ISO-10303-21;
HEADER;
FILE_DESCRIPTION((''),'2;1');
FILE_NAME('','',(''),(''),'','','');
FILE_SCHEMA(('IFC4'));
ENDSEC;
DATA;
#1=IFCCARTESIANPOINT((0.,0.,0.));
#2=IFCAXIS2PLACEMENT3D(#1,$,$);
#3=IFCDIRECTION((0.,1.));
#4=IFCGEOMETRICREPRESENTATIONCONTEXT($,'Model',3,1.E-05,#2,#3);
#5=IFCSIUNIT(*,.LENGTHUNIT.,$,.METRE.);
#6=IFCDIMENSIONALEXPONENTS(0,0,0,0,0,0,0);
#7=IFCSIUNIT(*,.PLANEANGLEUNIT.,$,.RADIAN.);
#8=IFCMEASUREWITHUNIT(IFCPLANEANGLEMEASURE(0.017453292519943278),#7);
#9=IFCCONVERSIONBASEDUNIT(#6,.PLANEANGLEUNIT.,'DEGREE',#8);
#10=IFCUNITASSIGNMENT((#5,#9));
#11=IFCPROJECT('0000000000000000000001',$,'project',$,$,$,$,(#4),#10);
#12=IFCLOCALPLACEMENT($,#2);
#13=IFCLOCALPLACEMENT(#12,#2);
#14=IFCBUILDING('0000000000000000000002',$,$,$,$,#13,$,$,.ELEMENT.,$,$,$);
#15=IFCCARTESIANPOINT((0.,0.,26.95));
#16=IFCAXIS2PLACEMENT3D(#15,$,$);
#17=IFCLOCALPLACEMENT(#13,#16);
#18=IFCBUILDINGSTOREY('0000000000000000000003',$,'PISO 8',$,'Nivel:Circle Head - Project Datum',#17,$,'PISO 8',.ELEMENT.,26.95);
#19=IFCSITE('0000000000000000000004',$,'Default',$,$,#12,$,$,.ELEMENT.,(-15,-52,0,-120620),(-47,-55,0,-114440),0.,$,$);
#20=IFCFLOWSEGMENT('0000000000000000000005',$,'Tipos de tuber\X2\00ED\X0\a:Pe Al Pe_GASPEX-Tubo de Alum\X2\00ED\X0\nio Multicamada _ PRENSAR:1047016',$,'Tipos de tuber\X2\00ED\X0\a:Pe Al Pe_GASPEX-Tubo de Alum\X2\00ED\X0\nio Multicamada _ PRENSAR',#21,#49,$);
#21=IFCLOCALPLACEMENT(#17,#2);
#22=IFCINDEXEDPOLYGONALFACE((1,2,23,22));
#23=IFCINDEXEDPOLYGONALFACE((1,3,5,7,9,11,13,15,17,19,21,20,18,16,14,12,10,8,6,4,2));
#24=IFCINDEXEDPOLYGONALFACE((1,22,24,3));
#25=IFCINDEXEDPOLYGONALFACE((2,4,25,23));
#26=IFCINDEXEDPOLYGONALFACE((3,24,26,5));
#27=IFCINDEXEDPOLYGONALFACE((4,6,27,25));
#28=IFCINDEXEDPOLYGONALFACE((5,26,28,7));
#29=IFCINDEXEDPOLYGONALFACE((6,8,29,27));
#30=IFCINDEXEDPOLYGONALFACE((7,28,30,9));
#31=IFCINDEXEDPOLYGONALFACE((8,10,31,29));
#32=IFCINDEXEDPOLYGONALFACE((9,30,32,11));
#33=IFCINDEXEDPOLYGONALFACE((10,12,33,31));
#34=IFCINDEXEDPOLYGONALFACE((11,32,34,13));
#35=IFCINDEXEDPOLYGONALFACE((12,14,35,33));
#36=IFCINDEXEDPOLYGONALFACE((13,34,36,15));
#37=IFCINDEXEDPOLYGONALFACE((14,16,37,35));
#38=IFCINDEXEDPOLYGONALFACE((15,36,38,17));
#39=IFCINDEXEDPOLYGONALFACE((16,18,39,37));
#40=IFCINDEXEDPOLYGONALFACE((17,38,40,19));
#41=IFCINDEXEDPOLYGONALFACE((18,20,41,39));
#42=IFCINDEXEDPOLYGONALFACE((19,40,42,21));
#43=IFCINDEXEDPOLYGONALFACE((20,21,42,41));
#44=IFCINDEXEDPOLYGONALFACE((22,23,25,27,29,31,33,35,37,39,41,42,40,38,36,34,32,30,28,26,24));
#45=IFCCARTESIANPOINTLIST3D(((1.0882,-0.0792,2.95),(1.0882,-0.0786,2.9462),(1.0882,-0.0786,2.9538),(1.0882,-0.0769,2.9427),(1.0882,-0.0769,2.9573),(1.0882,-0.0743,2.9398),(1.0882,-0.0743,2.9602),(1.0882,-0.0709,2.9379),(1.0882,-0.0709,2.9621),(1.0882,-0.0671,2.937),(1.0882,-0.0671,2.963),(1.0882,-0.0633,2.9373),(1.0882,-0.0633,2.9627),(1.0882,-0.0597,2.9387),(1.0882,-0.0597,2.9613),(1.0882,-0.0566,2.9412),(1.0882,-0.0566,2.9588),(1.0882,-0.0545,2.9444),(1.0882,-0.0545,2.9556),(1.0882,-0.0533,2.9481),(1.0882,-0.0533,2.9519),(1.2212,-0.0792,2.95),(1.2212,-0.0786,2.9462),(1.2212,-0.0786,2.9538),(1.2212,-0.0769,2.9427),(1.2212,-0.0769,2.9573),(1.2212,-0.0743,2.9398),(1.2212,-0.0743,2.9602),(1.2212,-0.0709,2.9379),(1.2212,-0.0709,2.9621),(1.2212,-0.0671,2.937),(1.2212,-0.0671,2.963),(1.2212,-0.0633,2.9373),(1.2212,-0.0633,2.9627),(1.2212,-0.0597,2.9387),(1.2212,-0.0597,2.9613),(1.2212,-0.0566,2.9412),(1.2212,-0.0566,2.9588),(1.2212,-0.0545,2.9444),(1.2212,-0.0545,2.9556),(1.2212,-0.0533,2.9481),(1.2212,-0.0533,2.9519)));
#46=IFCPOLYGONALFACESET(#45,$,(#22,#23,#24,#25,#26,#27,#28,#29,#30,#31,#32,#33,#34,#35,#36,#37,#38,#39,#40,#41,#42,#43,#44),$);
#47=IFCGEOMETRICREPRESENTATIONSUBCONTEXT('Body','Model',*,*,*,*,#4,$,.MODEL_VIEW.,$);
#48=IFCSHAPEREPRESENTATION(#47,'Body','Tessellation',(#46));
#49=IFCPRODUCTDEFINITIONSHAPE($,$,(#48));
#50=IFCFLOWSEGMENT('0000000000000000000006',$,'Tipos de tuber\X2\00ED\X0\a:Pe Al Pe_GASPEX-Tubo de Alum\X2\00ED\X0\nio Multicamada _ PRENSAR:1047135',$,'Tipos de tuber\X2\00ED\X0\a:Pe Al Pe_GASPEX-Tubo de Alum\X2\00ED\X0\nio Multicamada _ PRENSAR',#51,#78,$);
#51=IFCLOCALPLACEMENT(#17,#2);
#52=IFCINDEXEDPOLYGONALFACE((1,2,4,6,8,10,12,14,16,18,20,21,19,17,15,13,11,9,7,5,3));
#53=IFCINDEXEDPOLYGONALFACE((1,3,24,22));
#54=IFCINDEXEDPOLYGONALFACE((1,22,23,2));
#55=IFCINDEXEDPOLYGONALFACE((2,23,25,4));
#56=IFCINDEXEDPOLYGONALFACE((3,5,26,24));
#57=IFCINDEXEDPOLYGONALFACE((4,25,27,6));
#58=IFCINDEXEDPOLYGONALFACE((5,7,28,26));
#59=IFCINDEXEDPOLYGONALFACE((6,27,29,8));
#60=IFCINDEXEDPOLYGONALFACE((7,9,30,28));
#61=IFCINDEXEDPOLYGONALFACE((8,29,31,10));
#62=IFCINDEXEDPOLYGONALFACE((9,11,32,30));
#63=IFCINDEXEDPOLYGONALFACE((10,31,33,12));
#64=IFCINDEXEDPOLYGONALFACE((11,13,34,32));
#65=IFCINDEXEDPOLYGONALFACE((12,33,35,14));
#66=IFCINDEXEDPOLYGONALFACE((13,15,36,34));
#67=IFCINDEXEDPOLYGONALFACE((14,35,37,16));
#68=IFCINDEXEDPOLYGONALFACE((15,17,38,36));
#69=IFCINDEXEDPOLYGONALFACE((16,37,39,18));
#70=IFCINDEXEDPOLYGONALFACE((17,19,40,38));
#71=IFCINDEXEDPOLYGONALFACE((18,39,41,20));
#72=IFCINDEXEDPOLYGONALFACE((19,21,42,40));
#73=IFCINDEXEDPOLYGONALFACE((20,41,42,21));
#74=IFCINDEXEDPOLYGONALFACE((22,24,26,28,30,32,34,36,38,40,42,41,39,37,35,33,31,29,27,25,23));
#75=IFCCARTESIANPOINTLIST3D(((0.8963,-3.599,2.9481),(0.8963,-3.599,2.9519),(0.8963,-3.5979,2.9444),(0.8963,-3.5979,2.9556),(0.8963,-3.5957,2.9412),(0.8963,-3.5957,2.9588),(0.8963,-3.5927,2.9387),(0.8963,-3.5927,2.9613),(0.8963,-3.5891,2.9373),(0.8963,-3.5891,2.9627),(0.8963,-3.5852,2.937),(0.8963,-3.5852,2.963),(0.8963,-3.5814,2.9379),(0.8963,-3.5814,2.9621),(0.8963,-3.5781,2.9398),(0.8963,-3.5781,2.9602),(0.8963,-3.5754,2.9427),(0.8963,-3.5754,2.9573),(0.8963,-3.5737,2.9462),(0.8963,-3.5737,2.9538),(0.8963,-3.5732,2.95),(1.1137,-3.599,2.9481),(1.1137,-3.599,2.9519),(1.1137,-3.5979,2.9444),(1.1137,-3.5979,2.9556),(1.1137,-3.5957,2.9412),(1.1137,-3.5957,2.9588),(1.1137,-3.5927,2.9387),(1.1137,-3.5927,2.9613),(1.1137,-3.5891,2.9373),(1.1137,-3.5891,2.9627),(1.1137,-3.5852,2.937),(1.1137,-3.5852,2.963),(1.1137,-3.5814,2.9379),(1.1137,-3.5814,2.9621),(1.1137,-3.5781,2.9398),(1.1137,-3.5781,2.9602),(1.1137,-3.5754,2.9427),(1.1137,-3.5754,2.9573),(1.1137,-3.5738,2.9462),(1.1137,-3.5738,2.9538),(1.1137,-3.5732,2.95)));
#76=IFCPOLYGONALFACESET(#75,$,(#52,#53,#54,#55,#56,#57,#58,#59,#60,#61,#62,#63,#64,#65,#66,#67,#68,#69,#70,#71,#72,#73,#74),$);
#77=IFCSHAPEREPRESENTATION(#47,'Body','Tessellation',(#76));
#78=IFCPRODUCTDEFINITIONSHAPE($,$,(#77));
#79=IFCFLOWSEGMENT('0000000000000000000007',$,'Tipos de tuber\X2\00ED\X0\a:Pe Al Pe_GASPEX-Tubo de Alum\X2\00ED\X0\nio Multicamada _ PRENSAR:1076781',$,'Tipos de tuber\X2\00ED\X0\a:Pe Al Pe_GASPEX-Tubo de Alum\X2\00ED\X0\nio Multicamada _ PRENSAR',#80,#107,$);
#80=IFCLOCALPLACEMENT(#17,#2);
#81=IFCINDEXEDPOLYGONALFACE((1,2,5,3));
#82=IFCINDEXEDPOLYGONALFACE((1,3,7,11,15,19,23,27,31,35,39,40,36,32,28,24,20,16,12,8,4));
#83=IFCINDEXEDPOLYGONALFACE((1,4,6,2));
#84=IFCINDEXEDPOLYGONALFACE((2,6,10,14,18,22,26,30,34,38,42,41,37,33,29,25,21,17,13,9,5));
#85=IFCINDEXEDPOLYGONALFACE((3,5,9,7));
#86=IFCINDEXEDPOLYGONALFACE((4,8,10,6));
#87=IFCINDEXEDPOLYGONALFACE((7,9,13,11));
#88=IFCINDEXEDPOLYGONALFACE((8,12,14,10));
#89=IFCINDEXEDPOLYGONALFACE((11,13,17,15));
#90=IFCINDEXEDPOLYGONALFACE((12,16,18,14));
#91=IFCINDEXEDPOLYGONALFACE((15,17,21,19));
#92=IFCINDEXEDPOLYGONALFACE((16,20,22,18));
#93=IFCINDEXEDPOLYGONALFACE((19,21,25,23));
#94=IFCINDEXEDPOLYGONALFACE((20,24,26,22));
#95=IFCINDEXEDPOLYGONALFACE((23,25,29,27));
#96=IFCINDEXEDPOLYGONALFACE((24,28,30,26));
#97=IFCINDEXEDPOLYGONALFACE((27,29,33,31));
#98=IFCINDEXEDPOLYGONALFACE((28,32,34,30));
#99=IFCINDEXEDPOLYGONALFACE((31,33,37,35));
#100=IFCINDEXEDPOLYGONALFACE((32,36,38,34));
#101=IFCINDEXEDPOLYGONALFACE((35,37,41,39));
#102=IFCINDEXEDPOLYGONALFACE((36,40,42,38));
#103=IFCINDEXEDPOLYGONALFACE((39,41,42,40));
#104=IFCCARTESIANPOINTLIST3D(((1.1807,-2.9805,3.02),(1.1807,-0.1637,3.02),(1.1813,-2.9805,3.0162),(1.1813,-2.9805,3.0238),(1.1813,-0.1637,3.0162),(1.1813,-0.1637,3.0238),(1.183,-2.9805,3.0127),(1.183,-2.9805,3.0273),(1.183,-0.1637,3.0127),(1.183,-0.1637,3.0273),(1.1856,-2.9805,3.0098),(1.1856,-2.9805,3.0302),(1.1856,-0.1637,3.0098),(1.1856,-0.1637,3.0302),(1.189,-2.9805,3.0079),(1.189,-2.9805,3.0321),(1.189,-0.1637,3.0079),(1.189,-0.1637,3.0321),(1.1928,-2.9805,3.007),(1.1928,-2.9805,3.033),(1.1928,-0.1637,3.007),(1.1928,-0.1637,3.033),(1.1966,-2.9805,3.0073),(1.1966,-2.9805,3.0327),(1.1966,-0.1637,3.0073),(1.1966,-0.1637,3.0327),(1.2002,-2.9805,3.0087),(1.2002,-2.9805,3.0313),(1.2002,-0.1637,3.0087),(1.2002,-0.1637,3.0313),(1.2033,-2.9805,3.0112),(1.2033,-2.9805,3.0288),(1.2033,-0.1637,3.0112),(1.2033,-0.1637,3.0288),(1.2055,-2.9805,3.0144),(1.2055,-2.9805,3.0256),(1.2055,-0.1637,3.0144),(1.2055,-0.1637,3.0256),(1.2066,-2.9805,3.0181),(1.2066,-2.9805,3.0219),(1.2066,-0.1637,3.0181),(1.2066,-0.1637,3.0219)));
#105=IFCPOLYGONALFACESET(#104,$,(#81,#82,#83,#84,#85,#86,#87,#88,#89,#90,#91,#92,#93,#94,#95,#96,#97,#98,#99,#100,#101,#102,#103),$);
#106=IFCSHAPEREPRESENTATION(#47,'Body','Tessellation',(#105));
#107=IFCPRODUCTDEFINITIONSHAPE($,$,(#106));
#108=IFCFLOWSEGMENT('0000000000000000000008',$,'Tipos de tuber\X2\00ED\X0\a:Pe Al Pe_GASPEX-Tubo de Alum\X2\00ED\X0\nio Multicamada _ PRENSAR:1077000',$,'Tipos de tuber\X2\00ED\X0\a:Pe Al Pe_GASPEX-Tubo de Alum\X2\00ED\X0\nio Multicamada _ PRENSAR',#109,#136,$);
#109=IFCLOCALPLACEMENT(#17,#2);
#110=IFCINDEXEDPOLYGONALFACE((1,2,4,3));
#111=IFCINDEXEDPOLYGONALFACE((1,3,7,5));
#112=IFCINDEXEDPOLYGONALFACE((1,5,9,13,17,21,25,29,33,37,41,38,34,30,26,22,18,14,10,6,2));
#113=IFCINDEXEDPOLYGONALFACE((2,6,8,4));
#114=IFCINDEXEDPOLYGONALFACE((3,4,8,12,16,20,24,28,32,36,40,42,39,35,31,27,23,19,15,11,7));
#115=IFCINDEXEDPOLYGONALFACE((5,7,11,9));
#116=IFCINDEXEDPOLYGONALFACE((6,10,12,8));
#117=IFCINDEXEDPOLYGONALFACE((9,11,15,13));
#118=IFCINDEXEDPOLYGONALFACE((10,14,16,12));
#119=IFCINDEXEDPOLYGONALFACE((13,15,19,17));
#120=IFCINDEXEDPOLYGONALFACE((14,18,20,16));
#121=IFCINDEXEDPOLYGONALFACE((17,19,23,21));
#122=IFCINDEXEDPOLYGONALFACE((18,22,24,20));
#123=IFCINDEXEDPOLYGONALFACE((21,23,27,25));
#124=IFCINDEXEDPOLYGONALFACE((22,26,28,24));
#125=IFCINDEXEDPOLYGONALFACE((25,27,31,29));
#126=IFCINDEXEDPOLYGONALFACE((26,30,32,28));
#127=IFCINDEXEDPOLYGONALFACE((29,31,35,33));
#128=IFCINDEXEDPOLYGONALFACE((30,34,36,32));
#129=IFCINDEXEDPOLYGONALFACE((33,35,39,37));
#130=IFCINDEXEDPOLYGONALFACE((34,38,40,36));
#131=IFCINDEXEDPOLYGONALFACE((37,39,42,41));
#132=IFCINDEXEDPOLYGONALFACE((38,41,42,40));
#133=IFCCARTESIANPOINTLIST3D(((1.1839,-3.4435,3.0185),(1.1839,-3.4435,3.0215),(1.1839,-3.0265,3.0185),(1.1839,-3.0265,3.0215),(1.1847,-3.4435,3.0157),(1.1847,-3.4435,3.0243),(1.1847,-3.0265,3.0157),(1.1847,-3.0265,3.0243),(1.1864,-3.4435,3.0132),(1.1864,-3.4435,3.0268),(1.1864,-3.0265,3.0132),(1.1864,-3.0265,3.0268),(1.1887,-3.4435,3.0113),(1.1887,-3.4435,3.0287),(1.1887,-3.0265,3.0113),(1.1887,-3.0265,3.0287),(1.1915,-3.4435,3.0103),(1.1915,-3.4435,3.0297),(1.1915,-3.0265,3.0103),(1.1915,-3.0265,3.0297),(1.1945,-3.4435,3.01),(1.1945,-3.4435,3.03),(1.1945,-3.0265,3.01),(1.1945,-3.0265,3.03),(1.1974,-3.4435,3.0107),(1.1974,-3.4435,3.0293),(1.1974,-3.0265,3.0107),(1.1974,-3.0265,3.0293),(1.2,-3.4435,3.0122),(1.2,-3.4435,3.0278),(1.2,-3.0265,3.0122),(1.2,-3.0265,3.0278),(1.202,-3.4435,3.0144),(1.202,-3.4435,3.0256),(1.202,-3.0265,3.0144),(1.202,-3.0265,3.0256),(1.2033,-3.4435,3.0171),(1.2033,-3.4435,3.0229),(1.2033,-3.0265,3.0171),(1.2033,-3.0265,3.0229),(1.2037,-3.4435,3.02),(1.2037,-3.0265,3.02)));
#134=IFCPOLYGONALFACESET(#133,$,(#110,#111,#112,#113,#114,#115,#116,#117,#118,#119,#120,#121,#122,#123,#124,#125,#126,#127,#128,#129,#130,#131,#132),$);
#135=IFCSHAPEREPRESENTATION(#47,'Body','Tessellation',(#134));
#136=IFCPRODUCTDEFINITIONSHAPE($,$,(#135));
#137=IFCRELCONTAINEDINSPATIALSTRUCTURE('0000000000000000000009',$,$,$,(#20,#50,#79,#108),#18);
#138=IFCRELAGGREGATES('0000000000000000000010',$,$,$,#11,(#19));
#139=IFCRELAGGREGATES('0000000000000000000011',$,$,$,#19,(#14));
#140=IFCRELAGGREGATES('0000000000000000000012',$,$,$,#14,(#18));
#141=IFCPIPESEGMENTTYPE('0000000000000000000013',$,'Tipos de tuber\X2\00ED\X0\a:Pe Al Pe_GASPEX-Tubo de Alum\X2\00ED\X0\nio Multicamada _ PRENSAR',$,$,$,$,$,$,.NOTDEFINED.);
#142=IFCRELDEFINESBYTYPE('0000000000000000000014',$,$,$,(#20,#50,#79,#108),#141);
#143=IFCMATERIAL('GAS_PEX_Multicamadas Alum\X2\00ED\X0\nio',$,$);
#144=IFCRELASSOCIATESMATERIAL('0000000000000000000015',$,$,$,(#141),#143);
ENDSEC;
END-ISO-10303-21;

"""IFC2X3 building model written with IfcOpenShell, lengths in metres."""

from ifc_helpers import new_model, entity, si_unit, converted_unit, direction, frame, frame_2d, origin, origin_2d_with_axis, place, context, subcontext, project, spatial, circle, extrude, material, type_object, element, save


model = new_model("IFC2X3")

# Units and contexts
model_context = context("Model", 3, precision=1e-05, world=origin(), true_north=direction((0.0, 1.0)))
body_context = subcontext(model_context, "Body", "Model", "MODEL_VIEW")
ifc_project = project(units=[si_unit("LENGTHUNIT", "METRE"), converted_unit("PLANEANGLEUNIT", "DEGREE", entity("IfcPlaneAngleMeasure", 0.017453292519943278), si_unit("PLANEANGLEUNIT", "RADIAN"), dimensions=[0, 0, 0, 0, 0, 0, 0])], contexts=[model_context])

# Site, building, storey
site_placement = place(None, origin())
site = spatial("IfcSite", under=ifc_project, at=site_placement, Name="Default", CompositionType="ELEMENT", RefLatitude=(-15, -52, 0, -120620), RefLongitude=(-47, -55, 0, -114440), RefElevation=0.0)
building_placement = place(site_placement, origin())
building = spatial("IfcBuilding", under=site, at=building_placement, CompositionType="ELEMENT")
storey_placement = place(building_placement, frame((0.0, 0.0, 26.95)))
storey = spatial("IfcBuildingStorey", under=building, at=storey_placement, Name="PISO 8", ObjectType="Nivel:Circle Head - Project Datum", LongName="PISO 8", CompositionType="ELEMENT", Elevation=26.95)

# Flow segments
ifc_material = material(Name="GAS_PEX_Multicamadas Alumínio")
pipe_segment_type = type_object("IfcPipeSegmentType", Name="Tipos de tubería:Pe Al Pe_GASPEX-Tubo de Alumínio Multicamada _ PRENSAR", PredefinedType="NOTDEFINED", material=ifc_material)
flow_segment_1_placement = place(storey_placement, origin())
element("IfcFlowSegment", 1, at=flow_segment_1_placement, inside=storey, type_object=pipe_segment_type, Name="Tipos de tubería:Pe Al Pe_GASPEX-Tubo de Alumínio Multicamada _ PRENSAR:1047016", ObjectType="Tipos de tubería:Pe Al Pe_GASPEX-Tubo de Alumínio Multicamada _ PRENSAR", context=body_context, shape_type="SweptSolid", body=[
    extrude(circle(Radius=0.013, at=frame_2d((0.0, 0.0), x_axis=(1.0, 0.0))), frame((1.0882, -0.0662, 2.95), z_axis=(1.0, 0.0, 0.0), x_axis=(0.0, -1.0, 0.0)), (0.0, 0.0, 1.0), 0.133),
])
flow_segment_2_placement = place(storey_placement, origin())
element("IfcFlowSegment", 2, at=flow_segment_2_placement, inside=storey, type_object=pipe_segment_type, Name="Tipos de tubería:Pe Al Pe_GASPEX-Tubo de Alumínio Multicamada _ PRENSAR:1047135", ObjectType="Tipos de tubería:Pe Al Pe_GASPEX-Tubo de Alumínio Multicamada _ PRENSAR", context=body_context, shape_type="SweptSolid", body=[
    extrude(circle(Radius=0.013, at=origin_2d_with_axis()), frame((0.8963, -3.5862, 2.95), z_axis=(1.0, -0.000039, 0.0), x_axis=(0.000039, 1.0, 0.0)), (0.0, 0.0, 1.0), 0.2175),
])
flow_segment_3_placement = place(storey_placement, origin())
element("IfcFlowSegment", 3, at=flow_segment_3_placement, inside=storey, type_object=pipe_segment_type, Name="Tipos de tubería:Pe Al Pe_GASPEX-Tubo de Alumínio Multicamada _ PRENSAR:1076781", ObjectType="Tipos de tubería:Pe Al Pe_GASPEX-Tubo de Alumínio Multicamada _ PRENSAR", context=body_context, shape_type="SweptSolid", body=[
    extrude(circle(Radius=0.013, at=origin_2d_with_axis()), frame((1.1937, -2.9805, 3.02), z_axis=(0.0, 1.0, 0.0), x_axis=(-1.0, 0.0, 0.0)), (0.0, 0.0, 1.0), 2.8168),
])
flow_segment_4_placement = place(storey_placement, origin())
element("IfcFlowSegment", 4, at=flow_segment_4_placement, inside=storey, type_object=pipe_segment_type, Name="Tipos de tubería:Pe Al Pe_GASPEX-Tubo de Alumínio Multicamada _ PRENSAR:1077000", ObjectType="Tipos de tubería:Pe Al Pe_GASPEX-Tubo de Alumínio Multicamada _ PRENSAR", context=body_context, shape_type="SweptSolid", body=[
    extrude(circle(Radius=0.01, at=frame_2d((0.0, 0.0), x_axis=(1.0, 0.0))), frame((1.1937, -3.4435, 3.02), z_axis=(0.0, 1.0, 0.0), x_axis=(1.0, 0.0, 0.0)), (0.0, 0.0, 1.0), 0.417),
])

save(model, "model.ifc")
